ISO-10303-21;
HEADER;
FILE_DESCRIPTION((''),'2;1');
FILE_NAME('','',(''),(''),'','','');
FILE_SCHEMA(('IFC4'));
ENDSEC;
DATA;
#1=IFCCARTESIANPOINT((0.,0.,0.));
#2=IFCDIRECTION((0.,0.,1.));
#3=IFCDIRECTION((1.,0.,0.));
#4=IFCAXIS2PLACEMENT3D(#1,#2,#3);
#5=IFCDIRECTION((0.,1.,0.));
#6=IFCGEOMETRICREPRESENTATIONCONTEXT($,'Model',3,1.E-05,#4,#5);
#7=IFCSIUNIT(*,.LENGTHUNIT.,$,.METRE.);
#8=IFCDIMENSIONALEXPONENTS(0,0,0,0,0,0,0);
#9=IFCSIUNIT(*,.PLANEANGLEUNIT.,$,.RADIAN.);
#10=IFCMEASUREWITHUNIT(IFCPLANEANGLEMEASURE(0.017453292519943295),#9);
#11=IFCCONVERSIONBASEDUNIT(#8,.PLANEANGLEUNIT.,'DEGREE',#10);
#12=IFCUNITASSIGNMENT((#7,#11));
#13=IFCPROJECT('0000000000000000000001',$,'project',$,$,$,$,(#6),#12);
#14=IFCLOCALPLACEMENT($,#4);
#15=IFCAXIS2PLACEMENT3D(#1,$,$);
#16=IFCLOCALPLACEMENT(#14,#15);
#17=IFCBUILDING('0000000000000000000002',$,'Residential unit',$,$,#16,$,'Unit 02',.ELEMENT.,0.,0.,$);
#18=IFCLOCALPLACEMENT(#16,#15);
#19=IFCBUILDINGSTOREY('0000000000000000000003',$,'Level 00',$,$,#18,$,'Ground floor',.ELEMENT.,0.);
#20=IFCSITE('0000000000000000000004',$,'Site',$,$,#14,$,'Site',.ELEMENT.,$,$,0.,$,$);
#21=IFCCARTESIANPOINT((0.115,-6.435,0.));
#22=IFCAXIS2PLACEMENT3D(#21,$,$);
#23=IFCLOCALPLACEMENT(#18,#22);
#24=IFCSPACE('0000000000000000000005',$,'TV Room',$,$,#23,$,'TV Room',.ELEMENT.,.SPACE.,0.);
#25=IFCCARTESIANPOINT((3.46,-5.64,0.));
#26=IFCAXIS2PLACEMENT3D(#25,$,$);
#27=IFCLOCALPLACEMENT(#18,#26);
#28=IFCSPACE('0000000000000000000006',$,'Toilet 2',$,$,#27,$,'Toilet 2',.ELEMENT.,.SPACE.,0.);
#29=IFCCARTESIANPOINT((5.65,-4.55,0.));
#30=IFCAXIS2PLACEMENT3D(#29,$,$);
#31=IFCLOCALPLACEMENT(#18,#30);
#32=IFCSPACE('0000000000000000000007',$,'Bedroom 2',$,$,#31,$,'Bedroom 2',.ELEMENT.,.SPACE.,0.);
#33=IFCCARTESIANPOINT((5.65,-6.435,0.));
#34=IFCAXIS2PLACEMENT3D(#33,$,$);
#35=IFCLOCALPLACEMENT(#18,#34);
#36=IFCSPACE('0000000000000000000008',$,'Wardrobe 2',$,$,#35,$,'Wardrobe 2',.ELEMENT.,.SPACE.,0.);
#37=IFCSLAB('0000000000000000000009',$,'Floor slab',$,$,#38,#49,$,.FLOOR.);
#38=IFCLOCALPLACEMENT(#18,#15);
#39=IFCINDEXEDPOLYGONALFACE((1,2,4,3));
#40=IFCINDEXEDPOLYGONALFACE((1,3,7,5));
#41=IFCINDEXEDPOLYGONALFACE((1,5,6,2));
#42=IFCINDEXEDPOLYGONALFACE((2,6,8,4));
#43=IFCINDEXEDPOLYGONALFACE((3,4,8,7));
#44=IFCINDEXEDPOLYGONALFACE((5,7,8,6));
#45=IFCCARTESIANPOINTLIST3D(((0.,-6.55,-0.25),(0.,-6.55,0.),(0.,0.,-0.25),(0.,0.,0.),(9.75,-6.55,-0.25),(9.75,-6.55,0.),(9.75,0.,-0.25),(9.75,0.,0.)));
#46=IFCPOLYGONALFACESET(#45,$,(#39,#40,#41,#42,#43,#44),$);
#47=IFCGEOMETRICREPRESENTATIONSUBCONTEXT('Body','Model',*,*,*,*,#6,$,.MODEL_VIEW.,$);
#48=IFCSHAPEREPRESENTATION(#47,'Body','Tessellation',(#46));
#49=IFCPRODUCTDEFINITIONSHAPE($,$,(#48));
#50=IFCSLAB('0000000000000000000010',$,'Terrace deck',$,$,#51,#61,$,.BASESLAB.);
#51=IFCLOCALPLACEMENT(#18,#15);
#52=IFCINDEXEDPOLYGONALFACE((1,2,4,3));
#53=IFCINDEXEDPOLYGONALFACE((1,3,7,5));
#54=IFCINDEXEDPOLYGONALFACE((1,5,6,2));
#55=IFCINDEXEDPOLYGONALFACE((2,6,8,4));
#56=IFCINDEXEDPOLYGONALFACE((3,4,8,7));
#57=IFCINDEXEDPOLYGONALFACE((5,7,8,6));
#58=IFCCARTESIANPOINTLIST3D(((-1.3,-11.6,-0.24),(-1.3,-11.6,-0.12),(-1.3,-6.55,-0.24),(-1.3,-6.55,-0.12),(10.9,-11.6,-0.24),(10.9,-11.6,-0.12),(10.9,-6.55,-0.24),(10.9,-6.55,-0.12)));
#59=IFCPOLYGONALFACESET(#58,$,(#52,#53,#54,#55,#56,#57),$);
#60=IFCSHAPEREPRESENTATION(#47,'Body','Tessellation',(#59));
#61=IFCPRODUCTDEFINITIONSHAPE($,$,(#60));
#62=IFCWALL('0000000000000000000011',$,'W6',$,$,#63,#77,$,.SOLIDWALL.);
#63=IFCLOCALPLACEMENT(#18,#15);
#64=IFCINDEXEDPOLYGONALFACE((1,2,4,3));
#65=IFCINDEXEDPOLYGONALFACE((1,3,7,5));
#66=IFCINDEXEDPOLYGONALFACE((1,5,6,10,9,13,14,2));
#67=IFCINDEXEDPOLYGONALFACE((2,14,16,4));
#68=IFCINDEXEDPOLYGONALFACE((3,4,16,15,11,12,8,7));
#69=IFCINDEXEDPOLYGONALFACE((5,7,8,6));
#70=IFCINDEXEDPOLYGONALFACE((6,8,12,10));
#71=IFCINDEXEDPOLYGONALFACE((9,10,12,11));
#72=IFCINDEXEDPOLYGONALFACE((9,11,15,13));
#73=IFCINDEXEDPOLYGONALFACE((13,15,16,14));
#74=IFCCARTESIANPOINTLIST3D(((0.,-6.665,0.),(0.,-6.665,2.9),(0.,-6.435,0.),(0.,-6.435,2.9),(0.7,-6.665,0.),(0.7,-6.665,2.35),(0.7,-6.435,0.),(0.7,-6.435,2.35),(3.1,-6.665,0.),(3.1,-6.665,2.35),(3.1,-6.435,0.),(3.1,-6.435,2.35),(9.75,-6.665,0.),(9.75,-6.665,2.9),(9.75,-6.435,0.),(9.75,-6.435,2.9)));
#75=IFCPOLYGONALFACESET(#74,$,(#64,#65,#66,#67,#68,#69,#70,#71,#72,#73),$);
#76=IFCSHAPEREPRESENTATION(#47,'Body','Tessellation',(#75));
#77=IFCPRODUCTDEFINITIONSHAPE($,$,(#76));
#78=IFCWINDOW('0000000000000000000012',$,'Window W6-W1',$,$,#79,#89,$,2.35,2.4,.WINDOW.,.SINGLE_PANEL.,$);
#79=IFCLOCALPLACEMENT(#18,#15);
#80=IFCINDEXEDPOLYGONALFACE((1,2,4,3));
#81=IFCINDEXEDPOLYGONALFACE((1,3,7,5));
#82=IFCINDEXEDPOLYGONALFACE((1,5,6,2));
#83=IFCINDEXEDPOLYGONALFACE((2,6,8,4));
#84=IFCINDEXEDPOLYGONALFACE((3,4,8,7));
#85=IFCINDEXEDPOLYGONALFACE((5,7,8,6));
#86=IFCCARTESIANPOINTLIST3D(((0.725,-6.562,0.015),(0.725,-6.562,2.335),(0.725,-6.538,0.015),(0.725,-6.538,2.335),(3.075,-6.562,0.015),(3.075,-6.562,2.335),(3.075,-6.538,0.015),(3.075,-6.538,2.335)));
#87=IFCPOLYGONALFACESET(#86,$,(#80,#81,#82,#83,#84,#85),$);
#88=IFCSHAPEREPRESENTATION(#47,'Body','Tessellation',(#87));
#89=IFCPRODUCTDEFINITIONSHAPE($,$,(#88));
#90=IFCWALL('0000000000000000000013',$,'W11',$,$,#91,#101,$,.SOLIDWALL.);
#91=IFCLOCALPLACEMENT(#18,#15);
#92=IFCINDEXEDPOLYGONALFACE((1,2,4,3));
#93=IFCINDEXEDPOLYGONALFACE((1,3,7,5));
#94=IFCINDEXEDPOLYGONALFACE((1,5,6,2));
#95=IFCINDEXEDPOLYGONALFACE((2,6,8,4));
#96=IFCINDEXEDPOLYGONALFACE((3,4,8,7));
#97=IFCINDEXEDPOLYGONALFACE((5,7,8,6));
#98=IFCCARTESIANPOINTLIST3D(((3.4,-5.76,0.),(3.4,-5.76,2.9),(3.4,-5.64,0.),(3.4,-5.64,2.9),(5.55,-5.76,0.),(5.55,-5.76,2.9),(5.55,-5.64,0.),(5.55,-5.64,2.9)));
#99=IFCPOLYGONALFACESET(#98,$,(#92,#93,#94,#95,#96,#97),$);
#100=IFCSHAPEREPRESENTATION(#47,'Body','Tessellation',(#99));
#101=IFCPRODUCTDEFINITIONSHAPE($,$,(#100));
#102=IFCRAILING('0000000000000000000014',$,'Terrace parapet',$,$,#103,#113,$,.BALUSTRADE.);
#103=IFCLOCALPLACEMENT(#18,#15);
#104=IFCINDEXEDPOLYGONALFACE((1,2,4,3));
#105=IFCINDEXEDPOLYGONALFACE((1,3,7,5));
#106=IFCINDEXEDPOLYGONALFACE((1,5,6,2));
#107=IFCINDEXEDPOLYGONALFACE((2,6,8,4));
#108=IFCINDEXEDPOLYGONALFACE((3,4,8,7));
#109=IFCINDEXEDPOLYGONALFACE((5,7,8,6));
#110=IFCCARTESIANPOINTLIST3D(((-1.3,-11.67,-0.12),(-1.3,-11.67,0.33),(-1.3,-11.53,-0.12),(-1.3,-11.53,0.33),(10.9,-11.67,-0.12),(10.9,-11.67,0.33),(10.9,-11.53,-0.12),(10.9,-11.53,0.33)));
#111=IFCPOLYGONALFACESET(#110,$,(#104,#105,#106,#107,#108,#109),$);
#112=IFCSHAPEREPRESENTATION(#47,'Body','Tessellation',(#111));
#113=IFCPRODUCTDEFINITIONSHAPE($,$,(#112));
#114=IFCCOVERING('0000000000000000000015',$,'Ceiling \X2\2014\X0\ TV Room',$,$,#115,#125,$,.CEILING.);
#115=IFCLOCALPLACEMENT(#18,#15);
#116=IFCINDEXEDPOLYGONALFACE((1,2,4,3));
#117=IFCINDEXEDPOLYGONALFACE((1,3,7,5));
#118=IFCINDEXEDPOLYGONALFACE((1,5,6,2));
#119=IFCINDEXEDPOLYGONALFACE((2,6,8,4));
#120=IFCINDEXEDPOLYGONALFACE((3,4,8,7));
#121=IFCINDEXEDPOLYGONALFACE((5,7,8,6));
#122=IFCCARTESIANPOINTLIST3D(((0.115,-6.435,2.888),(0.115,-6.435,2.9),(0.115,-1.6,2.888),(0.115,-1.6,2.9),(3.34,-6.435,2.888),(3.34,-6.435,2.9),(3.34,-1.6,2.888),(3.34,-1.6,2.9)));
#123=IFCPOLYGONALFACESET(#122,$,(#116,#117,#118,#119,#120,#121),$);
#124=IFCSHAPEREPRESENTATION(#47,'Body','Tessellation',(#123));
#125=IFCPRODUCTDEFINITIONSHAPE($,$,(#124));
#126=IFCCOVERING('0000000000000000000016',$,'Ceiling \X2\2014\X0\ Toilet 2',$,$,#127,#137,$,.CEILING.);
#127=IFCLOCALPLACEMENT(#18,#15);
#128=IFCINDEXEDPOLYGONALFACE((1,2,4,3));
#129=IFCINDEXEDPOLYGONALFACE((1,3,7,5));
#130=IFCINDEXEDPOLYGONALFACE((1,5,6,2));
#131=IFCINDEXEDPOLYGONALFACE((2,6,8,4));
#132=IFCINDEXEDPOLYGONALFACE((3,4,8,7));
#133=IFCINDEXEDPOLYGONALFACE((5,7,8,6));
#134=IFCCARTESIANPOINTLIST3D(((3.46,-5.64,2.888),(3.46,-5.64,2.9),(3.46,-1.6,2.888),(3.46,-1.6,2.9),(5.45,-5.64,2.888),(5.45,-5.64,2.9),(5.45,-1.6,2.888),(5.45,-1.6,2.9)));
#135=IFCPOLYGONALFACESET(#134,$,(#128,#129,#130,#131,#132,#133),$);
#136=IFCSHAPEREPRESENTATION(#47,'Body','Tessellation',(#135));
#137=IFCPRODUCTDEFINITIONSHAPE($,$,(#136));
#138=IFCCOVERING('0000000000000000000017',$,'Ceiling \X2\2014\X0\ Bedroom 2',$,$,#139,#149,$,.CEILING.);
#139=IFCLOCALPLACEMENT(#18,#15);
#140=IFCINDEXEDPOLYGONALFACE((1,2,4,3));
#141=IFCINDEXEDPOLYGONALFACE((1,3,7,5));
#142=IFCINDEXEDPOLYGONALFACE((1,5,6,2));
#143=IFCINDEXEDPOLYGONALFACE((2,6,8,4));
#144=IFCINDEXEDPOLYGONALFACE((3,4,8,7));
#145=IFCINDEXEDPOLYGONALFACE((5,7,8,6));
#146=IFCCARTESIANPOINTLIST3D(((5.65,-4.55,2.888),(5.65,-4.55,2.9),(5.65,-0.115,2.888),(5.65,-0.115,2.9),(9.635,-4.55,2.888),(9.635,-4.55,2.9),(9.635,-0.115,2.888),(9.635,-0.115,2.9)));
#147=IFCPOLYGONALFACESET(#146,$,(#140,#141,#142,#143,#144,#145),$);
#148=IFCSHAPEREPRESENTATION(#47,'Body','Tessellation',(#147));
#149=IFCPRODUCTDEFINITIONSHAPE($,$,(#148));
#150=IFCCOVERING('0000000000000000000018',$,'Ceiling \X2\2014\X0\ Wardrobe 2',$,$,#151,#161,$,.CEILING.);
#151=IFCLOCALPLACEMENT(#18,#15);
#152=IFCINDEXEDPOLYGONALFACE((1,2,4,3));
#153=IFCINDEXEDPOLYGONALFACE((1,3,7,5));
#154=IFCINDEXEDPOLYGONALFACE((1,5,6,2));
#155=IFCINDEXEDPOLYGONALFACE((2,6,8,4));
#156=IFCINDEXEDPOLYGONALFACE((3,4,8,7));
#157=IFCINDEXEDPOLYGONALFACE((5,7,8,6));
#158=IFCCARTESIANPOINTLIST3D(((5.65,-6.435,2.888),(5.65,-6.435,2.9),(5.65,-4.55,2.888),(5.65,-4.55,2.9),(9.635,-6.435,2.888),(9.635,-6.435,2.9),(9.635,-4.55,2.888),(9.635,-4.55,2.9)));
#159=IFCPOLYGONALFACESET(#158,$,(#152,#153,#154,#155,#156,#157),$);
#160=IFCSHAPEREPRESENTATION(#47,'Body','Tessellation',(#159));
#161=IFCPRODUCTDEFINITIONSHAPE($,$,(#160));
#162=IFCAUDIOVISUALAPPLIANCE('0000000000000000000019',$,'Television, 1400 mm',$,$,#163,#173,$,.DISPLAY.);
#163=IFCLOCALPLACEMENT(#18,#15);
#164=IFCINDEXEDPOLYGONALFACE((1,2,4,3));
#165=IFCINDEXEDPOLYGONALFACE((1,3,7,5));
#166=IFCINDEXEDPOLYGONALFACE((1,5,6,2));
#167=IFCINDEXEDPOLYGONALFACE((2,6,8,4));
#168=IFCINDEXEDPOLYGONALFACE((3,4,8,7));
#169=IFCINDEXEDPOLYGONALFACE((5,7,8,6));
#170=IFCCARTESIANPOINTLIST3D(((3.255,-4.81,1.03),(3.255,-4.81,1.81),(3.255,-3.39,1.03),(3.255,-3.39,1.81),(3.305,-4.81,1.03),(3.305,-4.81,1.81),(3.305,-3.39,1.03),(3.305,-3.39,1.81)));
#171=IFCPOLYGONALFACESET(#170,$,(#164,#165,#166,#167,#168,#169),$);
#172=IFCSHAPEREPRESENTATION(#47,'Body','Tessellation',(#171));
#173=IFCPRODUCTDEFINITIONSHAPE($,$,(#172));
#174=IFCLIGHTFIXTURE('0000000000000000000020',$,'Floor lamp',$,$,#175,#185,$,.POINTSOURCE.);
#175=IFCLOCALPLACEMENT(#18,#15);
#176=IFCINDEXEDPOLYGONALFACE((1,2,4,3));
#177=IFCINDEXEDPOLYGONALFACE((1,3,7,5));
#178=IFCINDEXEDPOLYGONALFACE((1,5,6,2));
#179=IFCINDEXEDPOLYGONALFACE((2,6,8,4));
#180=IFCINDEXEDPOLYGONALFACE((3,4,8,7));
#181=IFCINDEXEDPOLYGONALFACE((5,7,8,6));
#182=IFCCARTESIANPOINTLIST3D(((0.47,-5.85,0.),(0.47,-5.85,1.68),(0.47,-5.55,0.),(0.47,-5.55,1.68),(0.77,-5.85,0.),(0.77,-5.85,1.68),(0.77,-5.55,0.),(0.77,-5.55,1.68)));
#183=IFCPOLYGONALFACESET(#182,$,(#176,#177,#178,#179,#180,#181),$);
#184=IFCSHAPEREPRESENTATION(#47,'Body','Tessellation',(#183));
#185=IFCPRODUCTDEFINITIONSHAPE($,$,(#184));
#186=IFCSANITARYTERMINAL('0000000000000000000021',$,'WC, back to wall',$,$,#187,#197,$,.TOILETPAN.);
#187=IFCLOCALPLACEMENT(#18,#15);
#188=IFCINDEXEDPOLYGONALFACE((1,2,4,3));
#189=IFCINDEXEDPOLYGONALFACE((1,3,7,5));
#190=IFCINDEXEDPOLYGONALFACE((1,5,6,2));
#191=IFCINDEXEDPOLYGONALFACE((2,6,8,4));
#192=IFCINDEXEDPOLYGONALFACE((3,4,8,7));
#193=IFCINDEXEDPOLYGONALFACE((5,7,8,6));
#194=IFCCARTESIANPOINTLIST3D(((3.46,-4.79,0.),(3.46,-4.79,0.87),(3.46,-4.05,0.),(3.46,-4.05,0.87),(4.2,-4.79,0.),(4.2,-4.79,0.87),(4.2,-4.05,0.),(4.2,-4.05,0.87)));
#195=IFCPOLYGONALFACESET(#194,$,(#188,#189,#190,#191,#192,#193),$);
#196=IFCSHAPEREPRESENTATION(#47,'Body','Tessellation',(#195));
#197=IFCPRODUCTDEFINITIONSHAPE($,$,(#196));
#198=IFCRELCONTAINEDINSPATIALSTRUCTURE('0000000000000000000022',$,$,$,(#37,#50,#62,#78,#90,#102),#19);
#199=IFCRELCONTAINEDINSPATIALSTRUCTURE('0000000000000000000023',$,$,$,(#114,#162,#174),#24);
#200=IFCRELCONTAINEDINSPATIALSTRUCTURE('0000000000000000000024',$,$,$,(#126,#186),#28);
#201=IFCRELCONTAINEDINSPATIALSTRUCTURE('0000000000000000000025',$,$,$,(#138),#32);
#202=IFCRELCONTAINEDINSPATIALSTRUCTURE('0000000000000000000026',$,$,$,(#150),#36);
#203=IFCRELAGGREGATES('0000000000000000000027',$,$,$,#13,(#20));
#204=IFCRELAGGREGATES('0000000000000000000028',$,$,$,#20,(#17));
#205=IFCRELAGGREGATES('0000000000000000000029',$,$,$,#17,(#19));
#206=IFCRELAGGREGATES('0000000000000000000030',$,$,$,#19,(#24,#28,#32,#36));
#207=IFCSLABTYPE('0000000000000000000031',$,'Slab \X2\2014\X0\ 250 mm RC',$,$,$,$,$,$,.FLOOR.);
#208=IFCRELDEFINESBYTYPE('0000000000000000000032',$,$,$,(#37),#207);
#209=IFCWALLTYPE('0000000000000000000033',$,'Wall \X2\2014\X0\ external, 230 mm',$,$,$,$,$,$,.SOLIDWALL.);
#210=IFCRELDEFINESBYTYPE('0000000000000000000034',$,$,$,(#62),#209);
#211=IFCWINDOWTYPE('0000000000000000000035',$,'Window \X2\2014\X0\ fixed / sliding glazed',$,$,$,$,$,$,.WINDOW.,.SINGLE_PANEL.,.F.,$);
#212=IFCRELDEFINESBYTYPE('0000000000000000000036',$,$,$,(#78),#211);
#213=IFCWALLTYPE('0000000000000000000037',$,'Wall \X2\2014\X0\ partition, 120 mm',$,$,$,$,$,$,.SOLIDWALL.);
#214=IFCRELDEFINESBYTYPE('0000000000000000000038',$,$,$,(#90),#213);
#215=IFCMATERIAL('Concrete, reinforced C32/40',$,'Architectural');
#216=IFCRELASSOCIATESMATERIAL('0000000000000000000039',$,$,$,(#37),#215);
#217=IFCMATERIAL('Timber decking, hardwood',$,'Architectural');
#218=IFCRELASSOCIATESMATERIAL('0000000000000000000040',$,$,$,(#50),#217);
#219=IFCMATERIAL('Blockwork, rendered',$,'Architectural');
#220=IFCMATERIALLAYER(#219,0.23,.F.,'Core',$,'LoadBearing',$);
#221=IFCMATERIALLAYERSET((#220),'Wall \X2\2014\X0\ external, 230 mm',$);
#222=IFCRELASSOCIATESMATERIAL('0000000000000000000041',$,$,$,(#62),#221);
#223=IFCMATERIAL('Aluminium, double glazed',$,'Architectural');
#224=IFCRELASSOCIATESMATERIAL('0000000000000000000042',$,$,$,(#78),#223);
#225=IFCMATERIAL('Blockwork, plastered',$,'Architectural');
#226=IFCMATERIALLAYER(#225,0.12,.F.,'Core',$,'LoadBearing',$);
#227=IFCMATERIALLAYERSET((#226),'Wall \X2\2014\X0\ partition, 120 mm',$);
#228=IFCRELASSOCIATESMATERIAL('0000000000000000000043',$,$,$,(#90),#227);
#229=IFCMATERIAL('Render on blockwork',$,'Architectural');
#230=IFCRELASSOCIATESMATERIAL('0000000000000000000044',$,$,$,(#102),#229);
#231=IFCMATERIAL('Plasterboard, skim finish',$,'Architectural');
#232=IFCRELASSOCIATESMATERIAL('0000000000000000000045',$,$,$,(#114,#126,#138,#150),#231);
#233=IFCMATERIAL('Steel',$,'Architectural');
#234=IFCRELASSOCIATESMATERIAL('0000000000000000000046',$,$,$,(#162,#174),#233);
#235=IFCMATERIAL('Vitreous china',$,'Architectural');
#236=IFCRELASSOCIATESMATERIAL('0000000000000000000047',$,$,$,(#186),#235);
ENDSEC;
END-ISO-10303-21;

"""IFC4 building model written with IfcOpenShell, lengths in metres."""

from ifc_helpers import new_model, entity, si_unit, converted_unit, direction, frame, frame_2d, origin, origin_with_axes, origin_2d, place, context, subcontext, project, spatial, rectangle, extrude, material, layer, layer_set, layer_usage, type_object, element, fill, save


model = new_model("IFC4")

# Units and contexts
model_context = context("Model", 3, precision=1e-05, world=origin_with_axes(), true_north=direction((0.0, 1.0, 0.0)))
body_context = subcontext(model_context, "Body", "Model", "MODEL_VIEW")
ifc_project = project(units=[si_unit("LENGTHUNIT", "METRE"), converted_unit("PLANEANGLEUNIT", "DEGREE", entity("IfcPlaneAngleMeasure", 0.017453292519943295), si_unit("PLANEANGLEUNIT", "RADIAN"), dimensions=[0, 0, 0, 0, 0, 0, 0])], contexts=[model_context])

# Site, building, storey
site_placement = place(None, origin_with_axes())
site = spatial("IfcSite", under=ifc_project, at=site_placement, Name="Site", LongName="Site", CompositionType="ELEMENT", RefElevation=0.0)
building_placement = place(site_placement, origin())
building = spatial("IfcBuilding", under=site, at=building_placement, Name="Residential unit", LongName="Unit 02", CompositionType="ELEMENT", ElevationOfRefHeight=0.0, ElevationOfTerrain=0.0)
storey_placement = place(building_placement, origin())
storey = spatial("IfcBuildingStorey", under=building, at=storey_placement, Name="Level 00", LongName="Ground floor", CompositionType="ELEMENT", Elevation=0.0)

# Slab
ifc_material_1 = material(Name="Concrete, reinforced C32/40", Category="Architectural")
slab_type = type_object("IfcSlabType", Name="Slab — 250 mm RC", PredefinedType="FLOOR")
slab_1_placement = place(storey_placement, frame((0.0, -6.55, -0.25)))
element("IfcSlab", 1, at=slab_1_placement, inside=storey, type_object=slab_type, material=ifc_material_1, Name="Floor slab", PredefinedType="FLOOR", context=body_context, shape_type="SweptSolid", body=[
    extrude(rectangle(XDim=9.75, YDim=6.55, at=frame_2d((4.875, 3.275))), origin(), (0.0, 0.0, 1.0), 0.25),
])

# Slab
ifc_material_2 = material(Name="Timber decking, hardwood", Category="Architectural")
slab_2_placement = place(storey_placement, frame((-1.3, -11.6, -0.24)))
element("IfcSlab", 2, at=slab_2_placement, inside=storey, material=ifc_material_2, Name="Terrace deck", PredefinedType="BASESLAB", context=body_context, shape_type="SweptSolid", body=[
    extrude(rectangle(XDim=12.2, YDim=5.05, at=frame_2d((6.1, 2.525))), origin(), (0.0, 0.0, 1.0), 0.12),
])

# Wall, opening, window
ifc_material_3 = material(Name="Blockwork, rendered", Category="Architectural")
ifc_layer_1 = layer(ifc_material_3, 0.23, ventilated=False, Name="Core", Category="LoadBearing")
ifc_layer_set_1 = layer_set([ifc_layer_1], Name="Wall — external, 230 mm")
ifc_layer_usage_1 = layer_usage(ifc_layer_set_1, "AXIS2", "POSITIVE", -0.115)
wall_type_1 = type_object("IfcWallType", Name="Wall — external, 230 mm", PredefinedType="SOLIDWALL")
wall_1_placement = place(storey_placement, frame((0.0, -6.55, 0.0), z_axis=(0.0, 0.0, 1.0), x_axis=(1.0, 0.0, 0.0)))
wall_1 = element("IfcWall", 3, at=wall_1_placement, inside=storey, type_object=wall_type_1, material=ifc_layer_usage_1, Name="W6", PredefinedType="SOLIDWALL", context=body_context, shape_type="SweptSolid", body=[
    extrude(rectangle(XDim=9.75, YDim=0.23, at=frame_2d((4.875, 0.0))), origin(), (0.0, 0.0, 1.0), 2.9),
])
opening_1_placement = place(wall_1_placement, frame((1.9, 0.0, 0.0)))
opening_1 = element("IfcOpeningElement", 4, at=opening_1_placement, cuts=wall_1, PredefinedType="OPENING", context=body_context, shape_type="SweptSolid", body=[
    extrude(rectangle(XDim=2.4, YDim=0.29, at=origin_2d()), origin(), (0.0, 0.0, 1.0), 2.35),
])
ifc_material_4 = material(Name="Aluminium, double glazed", Category="Architectural")
window_type = type_object("IfcWindowType", Name="Window — fixed / sliding glazed", ParameterTakesPrecedence=False, PartitioningType="SINGLE_PANEL", PredefinedType="WINDOW")
window_placement = place(wall_1_placement, frame((1.9, 0.0, 0.0)))
window = element("IfcWindow", 5, at=window_placement, inside=storey, type_object=window_type, material=ifc_material_4, Name="Window W6-W1", OverallHeight=2.35, OverallWidth=2.4, PartitioningType="SINGLE_PANEL", PredefinedType="WINDOW", context=body_context, shape_type="SweptSolid", body=[
    extrude(rectangle(XDim=2.35, YDim=0.024, at=origin_2d()), frame((0.0, 0.0, 0.015)), (0.0, 0.0, 1.0), 2.32),
])
fill(opening_1, window)

# Wall
ifc_material_5 = material(Name="Blockwork, plastered", Category="Architectural")
ifc_layer_2 = layer(ifc_material_5, 0.12, ventilated=False, Name="Core", Category="LoadBearing")
ifc_layer_set_2 = layer_set([ifc_layer_2], Name="Wall — partition, 120 mm")
ifc_layer_usage_2 = layer_usage(ifc_layer_set_2, "AXIS2", "POSITIVE", -0.06)
wall_type_2 = type_object("IfcWallType", Name="Wall — partition, 120 mm", PredefinedType="SOLIDWALL")
wall_2_placement = place(storey_placement, frame((3.4, -5.7, 0.0), z_axis=(0.0, 0.0, 1.0), x_axis=(1.0, 0.0, 0.0)))
element("IfcWall", 6, at=wall_2_placement, inside=storey, type_object=wall_type_2, material=ifc_layer_usage_2, Name="W11", PredefinedType="SOLIDWALL", context=body_context, shape_type="SweptSolid", body=[
    extrude(rectangle(XDim=2.15, YDim=0.12, at=frame_2d((1.075, 0.0))), origin(), (0.0, 0.0, 1.0), 2.9),
])

# Railing
ifc_material_6 = material(Name="Render on blockwork", Category="Architectural")
railing_placement = place(storey_placement, frame((-1.3, -11.67, -0.12)))
element("IfcRailing", 7, at=railing_placement, inside=storey, material=ifc_material_6, Name="Terrace parapet", PredefinedType="BALUSTRADE", context=body_context, shape_type="SweptSolid", body=[
    extrude(rectangle(XDim=12.2, YDim=0.14, at=frame_2d((6.1, 0.07))), origin(), (0.0, 0.0, 1.0), 0.45),
])

# Shared definitions
space_1_placement = place(storey_placement, frame((0.115, -6.435, 0.0)))
space_1 = spatial("IfcSpace", under=storey, at=space_1_placement, Name="TV Room", LongName="TV Room", CompositionType="ELEMENT", PredefinedType="SPACE", ElevationWithFlooring=0.0)

# Covering
ifc_material_7 = material(Name="Plasterboard, skim finish", Category="Architectural")
covering_1_placement = place(storey_placement, frame((0.115, -6.435, 2.888)))
element("IfcCovering", 8, at=covering_1_placement, inside=space_1, material=ifc_material_7, Name="Ceiling — TV Room", PredefinedType="CEILING", context=body_context, shape_type="SweptSolid", body=[
    extrude(rectangle(XDim=3.225, YDim=4.835, at=frame_2d((1.6125, 2.4175))), origin(), (0.0, 0.0, 1.0), 0.012),
])

# Shared definitions
space_2_placement = place(storey_placement, frame((3.46, -5.64, 0.0)))
space_2 = spatial("IfcSpace", under=storey, at=space_2_placement, Name="Toilet 2", LongName="Toilet 2", CompositionType="ELEMENT", PredefinedType="SPACE", ElevationWithFlooring=0.0)

# Covering
covering_2_placement = place(storey_placement, frame((3.46, -5.64, 2.888)))
element("IfcCovering", 9, at=covering_2_placement, inside=space_2, material=ifc_material_7, Name="Ceiling — Toilet 2", PredefinedType="CEILING", context=body_context, shape_type="SweptSolid", body=[
    extrude(rectangle(XDim=1.99, YDim=4.04, at=frame_2d((0.995, 2.02))), origin(), (0.0, 0.0, 1.0), 0.012),
])

# Shared definitions
space_3_placement = place(storey_placement, frame((5.65, -4.55, 0.0)))
space_3 = spatial("IfcSpace", under=storey, at=space_3_placement, Name="Bedroom 2", LongName="Bedroom 2", CompositionType="ELEMENT", PredefinedType="SPACE", ElevationWithFlooring=0.0)

# Covering
covering_3_placement = place(storey_placement, frame((5.65, -4.55, 2.888)))
element("IfcCovering", 10, at=covering_3_placement, inside=space_3, material=ifc_material_7, Name="Ceiling — Bedroom 2", PredefinedType="CEILING", context=body_context, shape_type="SweptSolid", body=[
    extrude(rectangle(XDim=3.985, YDim=4.435, at=frame_2d((1.9925, 2.2175))), origin(), (0.0, 0.0, 1.0), 0.012),
])

# Shared definitions
space_4_placement = place(storey_placement, frame((5.65, -6.435, 0.0)))
space_4 = spatial("IfcSpace", under=storey, at=space_4_placement, Name="Wardrobe 2", LongName="Wardrobe 2", CompositionType="ELEMENT", PredefinedType="SPACE", ElevationWithFlooring=0.0)

# Covering
covering_4_placement = place(storey_placement, frame((5.65, -6.435, 2.888)))
element("IfcCovering", 11, at=covering_4_placement, inside=space_4, material=ifc_material_7, Name="Ceiling — Wardrobe 2", PredefinedType="CEILING", context=body_context, shape_type="SweptSolid", body=[
    extrude(rectangle(XDim=3.985, YDim=1.885, at=frame_2d((1.9925, 0.9425))), origin(), (0.0, 0.0, 1.0), 0.012),
])

# Audio visual appliance
ifc_material_8 = material(Name="Steel", Category="Architectural")
audio_visual_appliance_1_placement = place(storey_placement, frame((3.255, -4.81, 1.03)))
element("IfcAudioVisualAppliance", 12, at=audio_visual_appliance_1_placement, inside=space_1, material=ifc_material_8, Name="Television, 1400 mm", PredefinedType="DISPLAY", context=body_context, shape_type="SweptSolid", body=[
    extrude(rectangle(XDim=0.05, YDim=1.42, at=frame_2d((0.025, 0.71))), origin(), (0.0, 0.0, 1.0), 0.78),
])

# Light fixture
light_fixture_1_placement = place(storey_placement, frame((0.47, -5.85, 0.0)))
element("IfcLightFixture", 13, at=light_fixture_1_placement, inside=space_1, material=ifc_material_8, Name="Floor lamp", PredefinedType="POINTSOURCE", context=body_context, shape_type="SweptSolid", body=[
    extrude(rectangle(XDim=0.3, YDim=0.3, at=frame_2d((0.15, 0.15))), origin(), (0.0, 0.0, 1.0), 1.68),
])

# Sanitary terminal
ifc_material_9 = material(Name="Vitreous china", Category="Architectural")
sanitary_terminal_1_placement = place(storey_placement, frame((3.46, -4.79, 0.0)))
element("IfcSanitaryTerminal", 14, at=sanitary_terminal_1_placement, inside=space_2, material=ifc_material_9, Name="WC, back to wall", PredefinedType="TOILETPAN", context=body_context, shape_type="SweptSolid", body=[
    extrude(rectangle(XDim=0.74, YDim=0.74, at=frame_2d((0.37, 0.37))), origin(), (0.0, 0.0, 1.0), 0.87),
])

save(model, "model.ifc")
